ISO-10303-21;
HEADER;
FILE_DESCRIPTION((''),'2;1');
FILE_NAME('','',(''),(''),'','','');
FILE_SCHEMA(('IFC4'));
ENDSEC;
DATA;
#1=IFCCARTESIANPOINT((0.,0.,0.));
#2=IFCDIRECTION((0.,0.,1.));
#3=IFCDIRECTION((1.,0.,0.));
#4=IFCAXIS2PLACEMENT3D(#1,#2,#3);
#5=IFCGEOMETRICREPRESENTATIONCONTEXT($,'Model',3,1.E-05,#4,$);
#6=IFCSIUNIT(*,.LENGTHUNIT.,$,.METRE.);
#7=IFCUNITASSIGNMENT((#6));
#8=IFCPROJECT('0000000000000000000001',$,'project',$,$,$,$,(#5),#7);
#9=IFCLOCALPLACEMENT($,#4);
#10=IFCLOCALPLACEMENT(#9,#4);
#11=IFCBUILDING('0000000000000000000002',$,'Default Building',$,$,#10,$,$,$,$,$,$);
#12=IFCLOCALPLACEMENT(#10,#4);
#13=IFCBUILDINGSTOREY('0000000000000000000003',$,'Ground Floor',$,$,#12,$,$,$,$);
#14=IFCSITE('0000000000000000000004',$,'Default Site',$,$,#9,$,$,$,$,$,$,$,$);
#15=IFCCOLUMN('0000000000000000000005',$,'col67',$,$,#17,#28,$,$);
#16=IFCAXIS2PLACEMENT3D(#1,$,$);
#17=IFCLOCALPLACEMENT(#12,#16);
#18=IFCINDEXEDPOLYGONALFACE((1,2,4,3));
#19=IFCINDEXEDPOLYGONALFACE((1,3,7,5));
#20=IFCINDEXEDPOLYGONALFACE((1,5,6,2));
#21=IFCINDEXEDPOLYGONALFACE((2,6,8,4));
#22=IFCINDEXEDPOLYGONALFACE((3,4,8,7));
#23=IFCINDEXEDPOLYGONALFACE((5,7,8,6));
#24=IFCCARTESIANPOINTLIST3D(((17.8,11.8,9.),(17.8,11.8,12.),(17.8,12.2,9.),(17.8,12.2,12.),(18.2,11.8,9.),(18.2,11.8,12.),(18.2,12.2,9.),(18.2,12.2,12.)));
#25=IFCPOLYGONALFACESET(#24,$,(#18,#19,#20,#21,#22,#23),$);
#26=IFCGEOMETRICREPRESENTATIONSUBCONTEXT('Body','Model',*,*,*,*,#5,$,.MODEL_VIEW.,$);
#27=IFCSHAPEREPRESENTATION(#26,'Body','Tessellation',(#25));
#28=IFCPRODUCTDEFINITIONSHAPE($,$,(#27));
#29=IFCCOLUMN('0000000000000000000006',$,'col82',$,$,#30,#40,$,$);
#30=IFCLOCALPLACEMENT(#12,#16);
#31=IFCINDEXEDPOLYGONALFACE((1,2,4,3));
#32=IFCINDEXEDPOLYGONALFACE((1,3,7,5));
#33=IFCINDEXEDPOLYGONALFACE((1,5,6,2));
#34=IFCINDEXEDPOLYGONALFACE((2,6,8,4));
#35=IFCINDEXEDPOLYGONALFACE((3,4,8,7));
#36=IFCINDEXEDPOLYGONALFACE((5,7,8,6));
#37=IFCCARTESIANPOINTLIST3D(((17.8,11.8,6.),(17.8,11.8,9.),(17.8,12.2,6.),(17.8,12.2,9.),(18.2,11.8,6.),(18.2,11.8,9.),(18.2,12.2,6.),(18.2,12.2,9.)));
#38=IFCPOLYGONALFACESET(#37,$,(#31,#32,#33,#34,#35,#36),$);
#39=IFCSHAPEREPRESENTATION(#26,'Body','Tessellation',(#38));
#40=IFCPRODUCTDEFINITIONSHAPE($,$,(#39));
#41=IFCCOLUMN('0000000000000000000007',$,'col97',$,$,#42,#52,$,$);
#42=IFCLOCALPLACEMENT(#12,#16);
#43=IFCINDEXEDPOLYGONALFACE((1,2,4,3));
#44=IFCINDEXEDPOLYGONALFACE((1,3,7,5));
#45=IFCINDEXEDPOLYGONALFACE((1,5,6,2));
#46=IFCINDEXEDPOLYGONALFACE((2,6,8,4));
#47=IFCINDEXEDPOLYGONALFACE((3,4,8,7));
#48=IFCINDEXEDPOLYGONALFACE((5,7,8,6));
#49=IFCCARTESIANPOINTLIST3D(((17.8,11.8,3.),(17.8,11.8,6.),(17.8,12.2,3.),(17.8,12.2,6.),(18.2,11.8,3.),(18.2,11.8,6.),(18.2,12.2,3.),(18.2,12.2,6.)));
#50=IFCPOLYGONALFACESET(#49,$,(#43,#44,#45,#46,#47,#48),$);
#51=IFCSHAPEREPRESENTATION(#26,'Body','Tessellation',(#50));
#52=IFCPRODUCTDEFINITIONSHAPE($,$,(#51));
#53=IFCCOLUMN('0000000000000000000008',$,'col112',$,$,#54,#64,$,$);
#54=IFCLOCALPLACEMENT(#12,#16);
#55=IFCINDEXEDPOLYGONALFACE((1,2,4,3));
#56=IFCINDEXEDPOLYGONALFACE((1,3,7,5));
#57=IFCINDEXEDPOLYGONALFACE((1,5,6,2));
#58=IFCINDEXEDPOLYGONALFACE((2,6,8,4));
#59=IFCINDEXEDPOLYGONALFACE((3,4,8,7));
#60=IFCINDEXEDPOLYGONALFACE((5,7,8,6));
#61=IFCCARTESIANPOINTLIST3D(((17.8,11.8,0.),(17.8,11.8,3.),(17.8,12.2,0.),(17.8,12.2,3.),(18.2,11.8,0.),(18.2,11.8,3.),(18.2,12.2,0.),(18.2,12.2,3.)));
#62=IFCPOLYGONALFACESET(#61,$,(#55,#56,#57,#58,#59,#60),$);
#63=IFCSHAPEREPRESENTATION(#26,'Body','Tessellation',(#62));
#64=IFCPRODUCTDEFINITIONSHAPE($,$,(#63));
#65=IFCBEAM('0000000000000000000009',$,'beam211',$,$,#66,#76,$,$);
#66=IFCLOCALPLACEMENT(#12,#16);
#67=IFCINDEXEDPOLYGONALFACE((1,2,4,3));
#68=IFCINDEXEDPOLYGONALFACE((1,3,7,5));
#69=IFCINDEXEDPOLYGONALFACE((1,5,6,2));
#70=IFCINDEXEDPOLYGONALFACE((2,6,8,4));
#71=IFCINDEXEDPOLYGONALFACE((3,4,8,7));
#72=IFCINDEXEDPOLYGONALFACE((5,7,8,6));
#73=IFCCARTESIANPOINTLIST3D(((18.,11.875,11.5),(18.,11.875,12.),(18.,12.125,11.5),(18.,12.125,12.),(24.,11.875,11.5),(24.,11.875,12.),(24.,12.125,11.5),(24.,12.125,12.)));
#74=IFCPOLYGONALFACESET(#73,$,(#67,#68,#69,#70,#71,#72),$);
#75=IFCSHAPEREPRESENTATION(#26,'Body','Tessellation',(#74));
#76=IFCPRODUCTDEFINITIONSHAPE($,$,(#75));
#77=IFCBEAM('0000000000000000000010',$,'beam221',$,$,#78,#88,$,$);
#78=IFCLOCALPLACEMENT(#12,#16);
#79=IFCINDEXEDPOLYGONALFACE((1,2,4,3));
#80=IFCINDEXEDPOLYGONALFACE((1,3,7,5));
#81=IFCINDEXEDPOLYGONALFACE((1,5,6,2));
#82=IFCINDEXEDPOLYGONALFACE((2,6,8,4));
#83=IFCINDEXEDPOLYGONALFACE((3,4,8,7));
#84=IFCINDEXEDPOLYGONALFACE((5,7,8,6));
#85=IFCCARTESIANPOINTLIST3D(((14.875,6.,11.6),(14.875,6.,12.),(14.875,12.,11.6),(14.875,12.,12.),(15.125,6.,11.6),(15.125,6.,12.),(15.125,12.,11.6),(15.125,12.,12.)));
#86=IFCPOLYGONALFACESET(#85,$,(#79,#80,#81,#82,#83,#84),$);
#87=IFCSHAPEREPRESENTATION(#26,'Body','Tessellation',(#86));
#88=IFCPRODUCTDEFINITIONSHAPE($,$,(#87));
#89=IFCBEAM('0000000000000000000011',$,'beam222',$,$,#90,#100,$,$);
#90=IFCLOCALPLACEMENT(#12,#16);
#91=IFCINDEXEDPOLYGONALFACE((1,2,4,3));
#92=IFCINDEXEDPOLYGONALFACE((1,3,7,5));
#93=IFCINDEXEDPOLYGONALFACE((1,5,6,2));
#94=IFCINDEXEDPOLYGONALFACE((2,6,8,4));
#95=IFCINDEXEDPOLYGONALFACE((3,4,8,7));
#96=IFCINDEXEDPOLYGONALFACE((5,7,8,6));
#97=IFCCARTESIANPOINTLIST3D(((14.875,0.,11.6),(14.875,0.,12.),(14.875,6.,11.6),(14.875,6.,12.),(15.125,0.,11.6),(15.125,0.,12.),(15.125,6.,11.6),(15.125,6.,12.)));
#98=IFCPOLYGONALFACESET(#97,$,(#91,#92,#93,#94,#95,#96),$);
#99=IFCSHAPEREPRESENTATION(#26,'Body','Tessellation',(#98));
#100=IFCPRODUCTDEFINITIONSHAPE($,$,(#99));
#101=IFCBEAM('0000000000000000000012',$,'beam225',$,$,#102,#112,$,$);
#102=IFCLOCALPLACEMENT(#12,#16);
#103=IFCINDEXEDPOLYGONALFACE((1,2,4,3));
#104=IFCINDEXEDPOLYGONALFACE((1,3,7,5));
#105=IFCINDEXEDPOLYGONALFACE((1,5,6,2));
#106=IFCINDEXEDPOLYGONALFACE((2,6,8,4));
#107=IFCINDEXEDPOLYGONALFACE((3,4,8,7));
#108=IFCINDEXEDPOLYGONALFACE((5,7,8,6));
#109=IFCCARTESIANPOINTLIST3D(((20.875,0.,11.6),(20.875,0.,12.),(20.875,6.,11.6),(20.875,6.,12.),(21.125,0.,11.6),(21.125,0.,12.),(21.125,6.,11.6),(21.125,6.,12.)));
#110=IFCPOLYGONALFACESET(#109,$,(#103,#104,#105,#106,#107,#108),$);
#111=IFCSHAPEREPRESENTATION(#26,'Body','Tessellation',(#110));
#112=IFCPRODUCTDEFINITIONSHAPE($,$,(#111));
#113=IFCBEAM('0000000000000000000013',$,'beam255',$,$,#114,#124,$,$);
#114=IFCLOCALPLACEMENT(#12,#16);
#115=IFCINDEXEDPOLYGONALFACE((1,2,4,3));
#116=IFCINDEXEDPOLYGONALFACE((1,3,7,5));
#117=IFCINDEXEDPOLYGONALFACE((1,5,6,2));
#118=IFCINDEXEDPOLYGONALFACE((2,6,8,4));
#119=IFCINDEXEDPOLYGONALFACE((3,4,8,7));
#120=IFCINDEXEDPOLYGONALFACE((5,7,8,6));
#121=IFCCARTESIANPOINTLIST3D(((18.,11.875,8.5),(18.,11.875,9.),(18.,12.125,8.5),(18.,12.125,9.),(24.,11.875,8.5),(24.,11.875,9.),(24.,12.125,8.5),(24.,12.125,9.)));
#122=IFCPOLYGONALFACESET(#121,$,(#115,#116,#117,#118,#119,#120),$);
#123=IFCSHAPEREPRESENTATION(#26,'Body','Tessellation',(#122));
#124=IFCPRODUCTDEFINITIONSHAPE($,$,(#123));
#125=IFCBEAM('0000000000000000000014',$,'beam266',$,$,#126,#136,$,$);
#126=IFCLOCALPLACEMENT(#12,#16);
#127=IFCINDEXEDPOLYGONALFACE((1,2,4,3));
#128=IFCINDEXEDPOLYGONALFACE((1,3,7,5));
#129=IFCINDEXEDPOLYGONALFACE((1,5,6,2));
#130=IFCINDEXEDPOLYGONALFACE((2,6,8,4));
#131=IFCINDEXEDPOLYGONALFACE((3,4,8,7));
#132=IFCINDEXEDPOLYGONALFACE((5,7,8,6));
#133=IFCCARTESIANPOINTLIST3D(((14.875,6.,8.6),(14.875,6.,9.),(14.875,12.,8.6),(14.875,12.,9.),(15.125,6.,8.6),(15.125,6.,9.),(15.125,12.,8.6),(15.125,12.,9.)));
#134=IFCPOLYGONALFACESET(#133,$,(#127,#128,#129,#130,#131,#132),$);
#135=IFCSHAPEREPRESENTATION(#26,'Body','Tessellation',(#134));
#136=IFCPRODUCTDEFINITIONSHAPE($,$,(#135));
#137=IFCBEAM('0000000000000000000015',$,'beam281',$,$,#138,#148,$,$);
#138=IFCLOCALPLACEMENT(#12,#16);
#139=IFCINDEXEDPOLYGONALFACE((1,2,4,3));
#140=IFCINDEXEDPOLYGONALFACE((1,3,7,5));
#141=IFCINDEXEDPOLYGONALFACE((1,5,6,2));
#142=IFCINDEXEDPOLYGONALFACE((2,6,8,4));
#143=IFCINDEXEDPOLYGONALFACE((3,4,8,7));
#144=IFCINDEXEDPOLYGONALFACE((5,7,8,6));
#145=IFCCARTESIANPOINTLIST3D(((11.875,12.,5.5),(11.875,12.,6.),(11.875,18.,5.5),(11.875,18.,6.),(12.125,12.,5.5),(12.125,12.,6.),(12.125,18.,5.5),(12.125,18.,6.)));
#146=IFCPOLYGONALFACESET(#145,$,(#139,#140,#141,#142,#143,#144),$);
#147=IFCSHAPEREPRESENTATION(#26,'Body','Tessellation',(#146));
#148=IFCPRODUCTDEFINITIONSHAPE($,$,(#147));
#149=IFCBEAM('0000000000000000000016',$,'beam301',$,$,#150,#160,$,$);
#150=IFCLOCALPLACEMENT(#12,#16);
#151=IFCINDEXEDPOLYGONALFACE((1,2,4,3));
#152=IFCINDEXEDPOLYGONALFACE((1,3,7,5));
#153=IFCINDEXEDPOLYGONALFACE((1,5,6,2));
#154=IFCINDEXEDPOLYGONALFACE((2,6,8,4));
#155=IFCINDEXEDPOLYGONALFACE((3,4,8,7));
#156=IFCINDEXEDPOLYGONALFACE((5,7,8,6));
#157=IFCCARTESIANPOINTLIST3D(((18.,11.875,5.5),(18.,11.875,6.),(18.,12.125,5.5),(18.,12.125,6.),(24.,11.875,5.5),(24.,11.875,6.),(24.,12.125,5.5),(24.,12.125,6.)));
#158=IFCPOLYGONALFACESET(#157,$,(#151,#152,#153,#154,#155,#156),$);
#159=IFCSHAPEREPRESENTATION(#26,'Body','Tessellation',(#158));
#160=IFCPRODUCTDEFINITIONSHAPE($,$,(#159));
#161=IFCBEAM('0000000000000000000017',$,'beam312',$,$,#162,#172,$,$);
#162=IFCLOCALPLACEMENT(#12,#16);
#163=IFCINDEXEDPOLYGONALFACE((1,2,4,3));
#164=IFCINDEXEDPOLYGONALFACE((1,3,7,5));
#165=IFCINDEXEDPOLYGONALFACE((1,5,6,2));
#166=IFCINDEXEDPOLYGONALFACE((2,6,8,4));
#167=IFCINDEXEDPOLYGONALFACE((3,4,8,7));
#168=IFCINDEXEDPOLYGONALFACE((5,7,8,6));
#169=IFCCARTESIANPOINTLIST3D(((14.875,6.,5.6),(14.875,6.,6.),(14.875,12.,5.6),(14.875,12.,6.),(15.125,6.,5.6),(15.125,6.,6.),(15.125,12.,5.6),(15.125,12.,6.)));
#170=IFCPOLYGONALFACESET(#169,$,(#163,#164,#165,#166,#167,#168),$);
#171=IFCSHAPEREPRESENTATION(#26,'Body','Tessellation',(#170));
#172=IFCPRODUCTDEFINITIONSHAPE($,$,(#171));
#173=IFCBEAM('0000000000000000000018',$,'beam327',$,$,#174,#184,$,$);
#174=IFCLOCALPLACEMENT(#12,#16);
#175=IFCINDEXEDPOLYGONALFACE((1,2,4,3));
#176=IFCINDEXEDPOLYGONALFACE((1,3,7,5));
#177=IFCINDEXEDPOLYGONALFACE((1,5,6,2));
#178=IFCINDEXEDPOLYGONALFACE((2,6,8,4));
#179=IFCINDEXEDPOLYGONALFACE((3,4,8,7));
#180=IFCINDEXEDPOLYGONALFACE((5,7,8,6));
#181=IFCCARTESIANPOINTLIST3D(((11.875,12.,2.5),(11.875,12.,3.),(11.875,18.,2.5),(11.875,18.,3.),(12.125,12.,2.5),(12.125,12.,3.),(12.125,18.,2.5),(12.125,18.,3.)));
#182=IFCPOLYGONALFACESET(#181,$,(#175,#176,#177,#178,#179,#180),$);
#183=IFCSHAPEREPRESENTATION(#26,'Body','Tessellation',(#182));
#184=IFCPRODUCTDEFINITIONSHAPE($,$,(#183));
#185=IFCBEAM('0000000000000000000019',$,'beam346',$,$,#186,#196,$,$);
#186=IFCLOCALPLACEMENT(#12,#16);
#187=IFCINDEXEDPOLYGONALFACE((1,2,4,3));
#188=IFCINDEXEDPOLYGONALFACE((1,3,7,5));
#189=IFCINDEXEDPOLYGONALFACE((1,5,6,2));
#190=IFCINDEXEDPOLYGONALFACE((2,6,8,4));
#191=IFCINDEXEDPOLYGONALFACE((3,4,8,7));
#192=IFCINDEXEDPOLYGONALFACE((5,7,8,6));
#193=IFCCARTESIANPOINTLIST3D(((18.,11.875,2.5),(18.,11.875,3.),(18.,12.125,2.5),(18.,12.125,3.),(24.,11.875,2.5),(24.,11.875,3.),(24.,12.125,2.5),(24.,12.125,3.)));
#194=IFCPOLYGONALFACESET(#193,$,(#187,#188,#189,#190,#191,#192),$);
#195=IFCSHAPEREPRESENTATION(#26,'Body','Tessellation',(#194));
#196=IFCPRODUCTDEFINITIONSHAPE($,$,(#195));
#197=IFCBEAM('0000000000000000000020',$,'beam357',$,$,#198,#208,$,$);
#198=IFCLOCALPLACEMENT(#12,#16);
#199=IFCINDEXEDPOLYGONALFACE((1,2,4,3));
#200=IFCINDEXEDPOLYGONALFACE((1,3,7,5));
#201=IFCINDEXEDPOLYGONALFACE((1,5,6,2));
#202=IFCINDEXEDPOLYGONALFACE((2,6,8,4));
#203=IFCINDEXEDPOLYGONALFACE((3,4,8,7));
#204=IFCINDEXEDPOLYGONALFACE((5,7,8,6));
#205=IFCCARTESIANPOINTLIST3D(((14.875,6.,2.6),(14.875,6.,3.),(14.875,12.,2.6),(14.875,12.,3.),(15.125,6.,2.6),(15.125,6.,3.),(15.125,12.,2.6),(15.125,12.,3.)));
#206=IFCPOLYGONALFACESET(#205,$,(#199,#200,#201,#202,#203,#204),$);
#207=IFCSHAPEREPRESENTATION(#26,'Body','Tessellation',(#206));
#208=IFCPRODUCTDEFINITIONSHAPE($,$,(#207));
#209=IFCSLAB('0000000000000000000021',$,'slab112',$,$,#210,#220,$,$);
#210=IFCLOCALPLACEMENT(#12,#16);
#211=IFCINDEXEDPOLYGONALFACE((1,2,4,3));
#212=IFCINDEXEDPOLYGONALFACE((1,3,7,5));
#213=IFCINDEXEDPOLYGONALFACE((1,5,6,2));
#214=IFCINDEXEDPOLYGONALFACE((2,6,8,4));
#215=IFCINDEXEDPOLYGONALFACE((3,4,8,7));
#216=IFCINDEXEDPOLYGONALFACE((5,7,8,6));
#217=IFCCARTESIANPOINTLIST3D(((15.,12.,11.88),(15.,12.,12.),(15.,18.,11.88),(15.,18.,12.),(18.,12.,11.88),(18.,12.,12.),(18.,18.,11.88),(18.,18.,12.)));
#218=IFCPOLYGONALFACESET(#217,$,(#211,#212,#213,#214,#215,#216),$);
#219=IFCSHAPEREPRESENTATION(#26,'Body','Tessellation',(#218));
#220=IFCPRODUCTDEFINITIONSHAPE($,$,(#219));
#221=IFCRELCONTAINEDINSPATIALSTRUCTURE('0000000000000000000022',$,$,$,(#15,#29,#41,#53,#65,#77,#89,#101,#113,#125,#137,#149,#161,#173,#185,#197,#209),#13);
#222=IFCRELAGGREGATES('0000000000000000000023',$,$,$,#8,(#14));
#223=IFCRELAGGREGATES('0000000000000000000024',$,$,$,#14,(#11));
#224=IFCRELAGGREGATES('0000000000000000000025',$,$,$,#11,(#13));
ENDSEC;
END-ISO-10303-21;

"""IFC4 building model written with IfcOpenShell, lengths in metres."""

from ifc_helpers import new_model, si_unit, frame, origin_with_axes, place, context, subcontext, project, spatial, indexed_curve, outline, extrude, element, save


model = new_model("IFC4")

# Units and contexts
model_context = context("Model", 3, precision=1e-05, world=origin_with_axes())
body_context = subcontext(model_context, "Body", "Model", "MODEL_VIEW")
ifc_project = project(units=[si_unit("LENGTHUNIT", "METRE")], contexts=[model_context])

# Site, building, storey
site_placement = place(None, origin_with_axes())
site = spatial("IfcSite", under=ifc_project, at=site_placement, Name="Default Site")
building_placement = place(site_placement, origin_with_axes())
building = spatial("IfcBuilding", under=site, at=building_placement, Name="Default Building")
storey_placement = place(building_placement, origin_with_axes())
storey = spatial("IfcBuildingStorey", under=building, at=storey_placement, Name="Ground Floor")

# Columns
for number, where, z_axis, x_axis, name in (
    (1, (17.8, 11.8, 9.0), (0.0, 0.0, 1.0), (1.0, 0.0, 0.0), "col67"),
    (2, (17.8, 11.8, 6.0), (0.0, 0.0, 1.0), (1.0, 0.0, 0.0), "col82"),
    (3, (17.8, 11.8, 3.0), (0.0, 0.0, 1.0), (1.0, 0.0, 0.0), "col97"),
    (4, (17.8, 11.8, 0.0), (0.0, 0.0, 1.0), (1.0, 0.0, 0.0), "col112"),
):
    element("IfcColumn", number, at=place(storey_placement, frame(where, z_axis=z_axis, x_axis=x_axis)), inside=storey, Name=name, context=body_context, shape_type="SweptSolid", body=[
        extrude(outline(indexed_curve([(0.0, 0.0), (0.0, 0.4), (0.4, 0.4), (0.4, 0.0), (0.0, 0.0)], self_intersect=False)), origin_with_axes(), (0.0, 0.0, 1.0), 3.0),
    ])

# Beams
beam_1_placement = place(storey_placement, frame((18.0, 11.875, 11.5), z_axis=(0.0, 0.0, 1.0), x_axis=(1.0, 0.0, 0.0)))
element("IfcBeam", 5, at=beam_1_placement, inside=storey, Name="beam211", context=body_context, shape_type="SweptSolid", body=[
    extrude(outline(indexed_curve([(0.0, 0.0), (0.0, 0.25), (6.0, 0.25), (6.0, 0.0), (0.0, 0.0)], self_intersect=False)), origin_with_axes(), (0.0, 0.0, 1.0), 0.5),
])
for number, where, z_axis, x_axis, name in (
    (6, (14.875, 12.0, 11.6), (0.0, 0.0, 1.0), (0.0, -1.0, 0.0), "beam221"),
    (7, (14.875, 6.0, 11.6), (0.0, 0.0, 1.0), (0.0, -1.0, 0.0), "beam222"),
    (8, (20.875, 6.0, 11.6), (0.0, 0.0, 1.0), (0.0, -1.0, 0.0), "beam225"),
):
    element("IfcBeam", number, at=place(storey_placement, frame(where, z_axis=z_axis, x_axis=x_axis)), inside=storey, Name=name, context=body_context, shape_type="SweptSolid", body=[
        extrude(outline(indexed_curve([(0.0, 0.0), (0.0, 0.25), (6.0, 0.25), (6.0, 0.0), (0.0, 0.0)], self_intersect=False)), origin_with_axes(), (0.0, 0.0, 1.0), 0.4),
    ])
beam_2_placement = place(storey_placement, frame((18.0, 11.875, 8.5), z_axis=(0.0, 0.0, 1.0), x_axis=(1.0, 0.0, 0.0)))
element("IfcBeam", 9, at=beam_2_placement, inside=storey, Name="beam255", context=body_context, shape_type="SweptSolid", body=[
    extrude(outline(indexed_curve([(0.0, 0.0), (0.0, 0.25), (6.0, 0.25), (6.0, 0.0), (0.0, 0.0)], self_intersect=False)), origin_with_axes(), (0.0, 0.0, 1.0), 0.5),
])
beam_3_placement = place(storey_placement, frame((14.875, 12.0, 8.6), z_axis=(0.0, 0.0, 1.0), x_axis=(0.0, -1.0, 0.0)))
element("IfcBeam", 10, at=beam_3_placement, inside=storey, Name="beam266", context=body_context, shape_type="SweptSolid", body=[
    extrude(outline(indexed_curve([(0.0, 0.0), (0.0, 0.25), (6.0, 0.25), (6.0, 0.0), (0.0, 0.0)], self_intersect=False)), origin_with_axes(), (0.0, 0.0, 1.0), 0.4),
])
for number, where, z_axis, x_axis, name in (
    (11, (12.125, 12.0, 5.5), (0.0, 0.0, 1.0), (0.0, 1.0, 0.0), "beam281"),
    (12, (18.0, 11.875, 5.5), (0.0, 0.0, 1.0), (1.0, 0.0, 0.0), "beam301"),
):
    element("IfcBeam", number, at=place(storey_placement, frame(where, z_axis=z_axis, x_axis=x_axis)), inside=storey, Name=name, context=body_context, shape_type="SweptSolid", body=[
        extrude(outline(indexed_curve([(0.0, 0.0), (0.0, 0.25), (6.0, 0.25), (6.0, 0.0), (0.0, 0.0)], self_intersect=False)), origin_with_axes(), (0.0, 0.0, 1.0), 0.5),
    ])
beam_4_placement = place(storey_placement, frame((14.875, 12.0, 5.6), z_axis=(0.0, 0.0, 1.0), x_axis=(0.0, -1.0, 0.0)))
element("IfcBeam", 13, at=beam_4_placement, inside=storey, Name="beam312", context=body_context, shape_type="SweptSolid", body=[
    extrude(outline(indexed_curve([(0.0, 0.0), (0.0, 0.25), (6.0, 0.25), (6.0, 0.0), (0.0, 0.0)], self_intersect=False)), origin_with_axes(), (0.0, 0.0, 1.0), 0.4),
])
for number, where, z_axis, x_axis, name in (
    (14, (12.125, 12.0, 2.5), (0.0, 0.0, 1.0), (0.0, 1.0, 0.0), "beam327"),
    (15, (18.0, 11.875, 2.5), (0.0, 0.0, 1.0), (1.0, 0.0, 0.0), "beam346"),
):
    element("IfcBeam", number, at=place(storey_placement, frame(where, z_axis=z_axis, x_axis=x_axis)), inside=storey, Name=name, context=body_context, shape_type="SweptSolid", body=[
        extrude(outline(indexed_curve([(0.0, 0.0), (0.0, 0.25), (6.0, 0.25), (6.0, 0.0), (0.0, 0.0)], self_intersect=False)), origin_with_axes(), (0.0, 0.0, 1.0), 0.5),
    ])
beam_5_placement = place(storey_placement, frame((14.875, 12.0, 2.6), z_axis=(0.0, 0.0, 1.0), x_axis=(0.0, -1.0, 0.0)))
element("IfcBeam", 16, at=beam_5_placement, inside=storey, Name="beam357", context=body_context, shape_type="SweptSolid", body=[
    extrude(outline(indexed_curve([(0.0, 0.0), (0.0, 0.25), (6.0, 0.25), (6.0, 0.0), (0.0, 0.0)], self_intersect=False)), origin_with_axes(), (0.0, 0.0, 1.0), 0.4),
])

# Slab
for number, where, z_axis, x_axis, name in (
    (17, (15.0, 12.0, 11.88), (0.0, 0.0, 1.0), (1.0, 0.0, 0.0), "slab112"),
):
    element("IfcSlab", number, at=place(storey_placement, frame(where, z_axis=z_axis, x_axis=x_axis)), inside=storey, Name=name, context=body_context, shape_type="SweptSolid", body=[
        extrude(outline(indexed_curve([(0.0, 0.0), (0.0, 6.0), (3.0, 6.0), (3.0, 0.0), (0.0, 0.0)], self_intersect=False)), origin_with_axes(), (0.0, 0.0, 1.0), 0.12),
    ])

save(model, "model.ifc")
